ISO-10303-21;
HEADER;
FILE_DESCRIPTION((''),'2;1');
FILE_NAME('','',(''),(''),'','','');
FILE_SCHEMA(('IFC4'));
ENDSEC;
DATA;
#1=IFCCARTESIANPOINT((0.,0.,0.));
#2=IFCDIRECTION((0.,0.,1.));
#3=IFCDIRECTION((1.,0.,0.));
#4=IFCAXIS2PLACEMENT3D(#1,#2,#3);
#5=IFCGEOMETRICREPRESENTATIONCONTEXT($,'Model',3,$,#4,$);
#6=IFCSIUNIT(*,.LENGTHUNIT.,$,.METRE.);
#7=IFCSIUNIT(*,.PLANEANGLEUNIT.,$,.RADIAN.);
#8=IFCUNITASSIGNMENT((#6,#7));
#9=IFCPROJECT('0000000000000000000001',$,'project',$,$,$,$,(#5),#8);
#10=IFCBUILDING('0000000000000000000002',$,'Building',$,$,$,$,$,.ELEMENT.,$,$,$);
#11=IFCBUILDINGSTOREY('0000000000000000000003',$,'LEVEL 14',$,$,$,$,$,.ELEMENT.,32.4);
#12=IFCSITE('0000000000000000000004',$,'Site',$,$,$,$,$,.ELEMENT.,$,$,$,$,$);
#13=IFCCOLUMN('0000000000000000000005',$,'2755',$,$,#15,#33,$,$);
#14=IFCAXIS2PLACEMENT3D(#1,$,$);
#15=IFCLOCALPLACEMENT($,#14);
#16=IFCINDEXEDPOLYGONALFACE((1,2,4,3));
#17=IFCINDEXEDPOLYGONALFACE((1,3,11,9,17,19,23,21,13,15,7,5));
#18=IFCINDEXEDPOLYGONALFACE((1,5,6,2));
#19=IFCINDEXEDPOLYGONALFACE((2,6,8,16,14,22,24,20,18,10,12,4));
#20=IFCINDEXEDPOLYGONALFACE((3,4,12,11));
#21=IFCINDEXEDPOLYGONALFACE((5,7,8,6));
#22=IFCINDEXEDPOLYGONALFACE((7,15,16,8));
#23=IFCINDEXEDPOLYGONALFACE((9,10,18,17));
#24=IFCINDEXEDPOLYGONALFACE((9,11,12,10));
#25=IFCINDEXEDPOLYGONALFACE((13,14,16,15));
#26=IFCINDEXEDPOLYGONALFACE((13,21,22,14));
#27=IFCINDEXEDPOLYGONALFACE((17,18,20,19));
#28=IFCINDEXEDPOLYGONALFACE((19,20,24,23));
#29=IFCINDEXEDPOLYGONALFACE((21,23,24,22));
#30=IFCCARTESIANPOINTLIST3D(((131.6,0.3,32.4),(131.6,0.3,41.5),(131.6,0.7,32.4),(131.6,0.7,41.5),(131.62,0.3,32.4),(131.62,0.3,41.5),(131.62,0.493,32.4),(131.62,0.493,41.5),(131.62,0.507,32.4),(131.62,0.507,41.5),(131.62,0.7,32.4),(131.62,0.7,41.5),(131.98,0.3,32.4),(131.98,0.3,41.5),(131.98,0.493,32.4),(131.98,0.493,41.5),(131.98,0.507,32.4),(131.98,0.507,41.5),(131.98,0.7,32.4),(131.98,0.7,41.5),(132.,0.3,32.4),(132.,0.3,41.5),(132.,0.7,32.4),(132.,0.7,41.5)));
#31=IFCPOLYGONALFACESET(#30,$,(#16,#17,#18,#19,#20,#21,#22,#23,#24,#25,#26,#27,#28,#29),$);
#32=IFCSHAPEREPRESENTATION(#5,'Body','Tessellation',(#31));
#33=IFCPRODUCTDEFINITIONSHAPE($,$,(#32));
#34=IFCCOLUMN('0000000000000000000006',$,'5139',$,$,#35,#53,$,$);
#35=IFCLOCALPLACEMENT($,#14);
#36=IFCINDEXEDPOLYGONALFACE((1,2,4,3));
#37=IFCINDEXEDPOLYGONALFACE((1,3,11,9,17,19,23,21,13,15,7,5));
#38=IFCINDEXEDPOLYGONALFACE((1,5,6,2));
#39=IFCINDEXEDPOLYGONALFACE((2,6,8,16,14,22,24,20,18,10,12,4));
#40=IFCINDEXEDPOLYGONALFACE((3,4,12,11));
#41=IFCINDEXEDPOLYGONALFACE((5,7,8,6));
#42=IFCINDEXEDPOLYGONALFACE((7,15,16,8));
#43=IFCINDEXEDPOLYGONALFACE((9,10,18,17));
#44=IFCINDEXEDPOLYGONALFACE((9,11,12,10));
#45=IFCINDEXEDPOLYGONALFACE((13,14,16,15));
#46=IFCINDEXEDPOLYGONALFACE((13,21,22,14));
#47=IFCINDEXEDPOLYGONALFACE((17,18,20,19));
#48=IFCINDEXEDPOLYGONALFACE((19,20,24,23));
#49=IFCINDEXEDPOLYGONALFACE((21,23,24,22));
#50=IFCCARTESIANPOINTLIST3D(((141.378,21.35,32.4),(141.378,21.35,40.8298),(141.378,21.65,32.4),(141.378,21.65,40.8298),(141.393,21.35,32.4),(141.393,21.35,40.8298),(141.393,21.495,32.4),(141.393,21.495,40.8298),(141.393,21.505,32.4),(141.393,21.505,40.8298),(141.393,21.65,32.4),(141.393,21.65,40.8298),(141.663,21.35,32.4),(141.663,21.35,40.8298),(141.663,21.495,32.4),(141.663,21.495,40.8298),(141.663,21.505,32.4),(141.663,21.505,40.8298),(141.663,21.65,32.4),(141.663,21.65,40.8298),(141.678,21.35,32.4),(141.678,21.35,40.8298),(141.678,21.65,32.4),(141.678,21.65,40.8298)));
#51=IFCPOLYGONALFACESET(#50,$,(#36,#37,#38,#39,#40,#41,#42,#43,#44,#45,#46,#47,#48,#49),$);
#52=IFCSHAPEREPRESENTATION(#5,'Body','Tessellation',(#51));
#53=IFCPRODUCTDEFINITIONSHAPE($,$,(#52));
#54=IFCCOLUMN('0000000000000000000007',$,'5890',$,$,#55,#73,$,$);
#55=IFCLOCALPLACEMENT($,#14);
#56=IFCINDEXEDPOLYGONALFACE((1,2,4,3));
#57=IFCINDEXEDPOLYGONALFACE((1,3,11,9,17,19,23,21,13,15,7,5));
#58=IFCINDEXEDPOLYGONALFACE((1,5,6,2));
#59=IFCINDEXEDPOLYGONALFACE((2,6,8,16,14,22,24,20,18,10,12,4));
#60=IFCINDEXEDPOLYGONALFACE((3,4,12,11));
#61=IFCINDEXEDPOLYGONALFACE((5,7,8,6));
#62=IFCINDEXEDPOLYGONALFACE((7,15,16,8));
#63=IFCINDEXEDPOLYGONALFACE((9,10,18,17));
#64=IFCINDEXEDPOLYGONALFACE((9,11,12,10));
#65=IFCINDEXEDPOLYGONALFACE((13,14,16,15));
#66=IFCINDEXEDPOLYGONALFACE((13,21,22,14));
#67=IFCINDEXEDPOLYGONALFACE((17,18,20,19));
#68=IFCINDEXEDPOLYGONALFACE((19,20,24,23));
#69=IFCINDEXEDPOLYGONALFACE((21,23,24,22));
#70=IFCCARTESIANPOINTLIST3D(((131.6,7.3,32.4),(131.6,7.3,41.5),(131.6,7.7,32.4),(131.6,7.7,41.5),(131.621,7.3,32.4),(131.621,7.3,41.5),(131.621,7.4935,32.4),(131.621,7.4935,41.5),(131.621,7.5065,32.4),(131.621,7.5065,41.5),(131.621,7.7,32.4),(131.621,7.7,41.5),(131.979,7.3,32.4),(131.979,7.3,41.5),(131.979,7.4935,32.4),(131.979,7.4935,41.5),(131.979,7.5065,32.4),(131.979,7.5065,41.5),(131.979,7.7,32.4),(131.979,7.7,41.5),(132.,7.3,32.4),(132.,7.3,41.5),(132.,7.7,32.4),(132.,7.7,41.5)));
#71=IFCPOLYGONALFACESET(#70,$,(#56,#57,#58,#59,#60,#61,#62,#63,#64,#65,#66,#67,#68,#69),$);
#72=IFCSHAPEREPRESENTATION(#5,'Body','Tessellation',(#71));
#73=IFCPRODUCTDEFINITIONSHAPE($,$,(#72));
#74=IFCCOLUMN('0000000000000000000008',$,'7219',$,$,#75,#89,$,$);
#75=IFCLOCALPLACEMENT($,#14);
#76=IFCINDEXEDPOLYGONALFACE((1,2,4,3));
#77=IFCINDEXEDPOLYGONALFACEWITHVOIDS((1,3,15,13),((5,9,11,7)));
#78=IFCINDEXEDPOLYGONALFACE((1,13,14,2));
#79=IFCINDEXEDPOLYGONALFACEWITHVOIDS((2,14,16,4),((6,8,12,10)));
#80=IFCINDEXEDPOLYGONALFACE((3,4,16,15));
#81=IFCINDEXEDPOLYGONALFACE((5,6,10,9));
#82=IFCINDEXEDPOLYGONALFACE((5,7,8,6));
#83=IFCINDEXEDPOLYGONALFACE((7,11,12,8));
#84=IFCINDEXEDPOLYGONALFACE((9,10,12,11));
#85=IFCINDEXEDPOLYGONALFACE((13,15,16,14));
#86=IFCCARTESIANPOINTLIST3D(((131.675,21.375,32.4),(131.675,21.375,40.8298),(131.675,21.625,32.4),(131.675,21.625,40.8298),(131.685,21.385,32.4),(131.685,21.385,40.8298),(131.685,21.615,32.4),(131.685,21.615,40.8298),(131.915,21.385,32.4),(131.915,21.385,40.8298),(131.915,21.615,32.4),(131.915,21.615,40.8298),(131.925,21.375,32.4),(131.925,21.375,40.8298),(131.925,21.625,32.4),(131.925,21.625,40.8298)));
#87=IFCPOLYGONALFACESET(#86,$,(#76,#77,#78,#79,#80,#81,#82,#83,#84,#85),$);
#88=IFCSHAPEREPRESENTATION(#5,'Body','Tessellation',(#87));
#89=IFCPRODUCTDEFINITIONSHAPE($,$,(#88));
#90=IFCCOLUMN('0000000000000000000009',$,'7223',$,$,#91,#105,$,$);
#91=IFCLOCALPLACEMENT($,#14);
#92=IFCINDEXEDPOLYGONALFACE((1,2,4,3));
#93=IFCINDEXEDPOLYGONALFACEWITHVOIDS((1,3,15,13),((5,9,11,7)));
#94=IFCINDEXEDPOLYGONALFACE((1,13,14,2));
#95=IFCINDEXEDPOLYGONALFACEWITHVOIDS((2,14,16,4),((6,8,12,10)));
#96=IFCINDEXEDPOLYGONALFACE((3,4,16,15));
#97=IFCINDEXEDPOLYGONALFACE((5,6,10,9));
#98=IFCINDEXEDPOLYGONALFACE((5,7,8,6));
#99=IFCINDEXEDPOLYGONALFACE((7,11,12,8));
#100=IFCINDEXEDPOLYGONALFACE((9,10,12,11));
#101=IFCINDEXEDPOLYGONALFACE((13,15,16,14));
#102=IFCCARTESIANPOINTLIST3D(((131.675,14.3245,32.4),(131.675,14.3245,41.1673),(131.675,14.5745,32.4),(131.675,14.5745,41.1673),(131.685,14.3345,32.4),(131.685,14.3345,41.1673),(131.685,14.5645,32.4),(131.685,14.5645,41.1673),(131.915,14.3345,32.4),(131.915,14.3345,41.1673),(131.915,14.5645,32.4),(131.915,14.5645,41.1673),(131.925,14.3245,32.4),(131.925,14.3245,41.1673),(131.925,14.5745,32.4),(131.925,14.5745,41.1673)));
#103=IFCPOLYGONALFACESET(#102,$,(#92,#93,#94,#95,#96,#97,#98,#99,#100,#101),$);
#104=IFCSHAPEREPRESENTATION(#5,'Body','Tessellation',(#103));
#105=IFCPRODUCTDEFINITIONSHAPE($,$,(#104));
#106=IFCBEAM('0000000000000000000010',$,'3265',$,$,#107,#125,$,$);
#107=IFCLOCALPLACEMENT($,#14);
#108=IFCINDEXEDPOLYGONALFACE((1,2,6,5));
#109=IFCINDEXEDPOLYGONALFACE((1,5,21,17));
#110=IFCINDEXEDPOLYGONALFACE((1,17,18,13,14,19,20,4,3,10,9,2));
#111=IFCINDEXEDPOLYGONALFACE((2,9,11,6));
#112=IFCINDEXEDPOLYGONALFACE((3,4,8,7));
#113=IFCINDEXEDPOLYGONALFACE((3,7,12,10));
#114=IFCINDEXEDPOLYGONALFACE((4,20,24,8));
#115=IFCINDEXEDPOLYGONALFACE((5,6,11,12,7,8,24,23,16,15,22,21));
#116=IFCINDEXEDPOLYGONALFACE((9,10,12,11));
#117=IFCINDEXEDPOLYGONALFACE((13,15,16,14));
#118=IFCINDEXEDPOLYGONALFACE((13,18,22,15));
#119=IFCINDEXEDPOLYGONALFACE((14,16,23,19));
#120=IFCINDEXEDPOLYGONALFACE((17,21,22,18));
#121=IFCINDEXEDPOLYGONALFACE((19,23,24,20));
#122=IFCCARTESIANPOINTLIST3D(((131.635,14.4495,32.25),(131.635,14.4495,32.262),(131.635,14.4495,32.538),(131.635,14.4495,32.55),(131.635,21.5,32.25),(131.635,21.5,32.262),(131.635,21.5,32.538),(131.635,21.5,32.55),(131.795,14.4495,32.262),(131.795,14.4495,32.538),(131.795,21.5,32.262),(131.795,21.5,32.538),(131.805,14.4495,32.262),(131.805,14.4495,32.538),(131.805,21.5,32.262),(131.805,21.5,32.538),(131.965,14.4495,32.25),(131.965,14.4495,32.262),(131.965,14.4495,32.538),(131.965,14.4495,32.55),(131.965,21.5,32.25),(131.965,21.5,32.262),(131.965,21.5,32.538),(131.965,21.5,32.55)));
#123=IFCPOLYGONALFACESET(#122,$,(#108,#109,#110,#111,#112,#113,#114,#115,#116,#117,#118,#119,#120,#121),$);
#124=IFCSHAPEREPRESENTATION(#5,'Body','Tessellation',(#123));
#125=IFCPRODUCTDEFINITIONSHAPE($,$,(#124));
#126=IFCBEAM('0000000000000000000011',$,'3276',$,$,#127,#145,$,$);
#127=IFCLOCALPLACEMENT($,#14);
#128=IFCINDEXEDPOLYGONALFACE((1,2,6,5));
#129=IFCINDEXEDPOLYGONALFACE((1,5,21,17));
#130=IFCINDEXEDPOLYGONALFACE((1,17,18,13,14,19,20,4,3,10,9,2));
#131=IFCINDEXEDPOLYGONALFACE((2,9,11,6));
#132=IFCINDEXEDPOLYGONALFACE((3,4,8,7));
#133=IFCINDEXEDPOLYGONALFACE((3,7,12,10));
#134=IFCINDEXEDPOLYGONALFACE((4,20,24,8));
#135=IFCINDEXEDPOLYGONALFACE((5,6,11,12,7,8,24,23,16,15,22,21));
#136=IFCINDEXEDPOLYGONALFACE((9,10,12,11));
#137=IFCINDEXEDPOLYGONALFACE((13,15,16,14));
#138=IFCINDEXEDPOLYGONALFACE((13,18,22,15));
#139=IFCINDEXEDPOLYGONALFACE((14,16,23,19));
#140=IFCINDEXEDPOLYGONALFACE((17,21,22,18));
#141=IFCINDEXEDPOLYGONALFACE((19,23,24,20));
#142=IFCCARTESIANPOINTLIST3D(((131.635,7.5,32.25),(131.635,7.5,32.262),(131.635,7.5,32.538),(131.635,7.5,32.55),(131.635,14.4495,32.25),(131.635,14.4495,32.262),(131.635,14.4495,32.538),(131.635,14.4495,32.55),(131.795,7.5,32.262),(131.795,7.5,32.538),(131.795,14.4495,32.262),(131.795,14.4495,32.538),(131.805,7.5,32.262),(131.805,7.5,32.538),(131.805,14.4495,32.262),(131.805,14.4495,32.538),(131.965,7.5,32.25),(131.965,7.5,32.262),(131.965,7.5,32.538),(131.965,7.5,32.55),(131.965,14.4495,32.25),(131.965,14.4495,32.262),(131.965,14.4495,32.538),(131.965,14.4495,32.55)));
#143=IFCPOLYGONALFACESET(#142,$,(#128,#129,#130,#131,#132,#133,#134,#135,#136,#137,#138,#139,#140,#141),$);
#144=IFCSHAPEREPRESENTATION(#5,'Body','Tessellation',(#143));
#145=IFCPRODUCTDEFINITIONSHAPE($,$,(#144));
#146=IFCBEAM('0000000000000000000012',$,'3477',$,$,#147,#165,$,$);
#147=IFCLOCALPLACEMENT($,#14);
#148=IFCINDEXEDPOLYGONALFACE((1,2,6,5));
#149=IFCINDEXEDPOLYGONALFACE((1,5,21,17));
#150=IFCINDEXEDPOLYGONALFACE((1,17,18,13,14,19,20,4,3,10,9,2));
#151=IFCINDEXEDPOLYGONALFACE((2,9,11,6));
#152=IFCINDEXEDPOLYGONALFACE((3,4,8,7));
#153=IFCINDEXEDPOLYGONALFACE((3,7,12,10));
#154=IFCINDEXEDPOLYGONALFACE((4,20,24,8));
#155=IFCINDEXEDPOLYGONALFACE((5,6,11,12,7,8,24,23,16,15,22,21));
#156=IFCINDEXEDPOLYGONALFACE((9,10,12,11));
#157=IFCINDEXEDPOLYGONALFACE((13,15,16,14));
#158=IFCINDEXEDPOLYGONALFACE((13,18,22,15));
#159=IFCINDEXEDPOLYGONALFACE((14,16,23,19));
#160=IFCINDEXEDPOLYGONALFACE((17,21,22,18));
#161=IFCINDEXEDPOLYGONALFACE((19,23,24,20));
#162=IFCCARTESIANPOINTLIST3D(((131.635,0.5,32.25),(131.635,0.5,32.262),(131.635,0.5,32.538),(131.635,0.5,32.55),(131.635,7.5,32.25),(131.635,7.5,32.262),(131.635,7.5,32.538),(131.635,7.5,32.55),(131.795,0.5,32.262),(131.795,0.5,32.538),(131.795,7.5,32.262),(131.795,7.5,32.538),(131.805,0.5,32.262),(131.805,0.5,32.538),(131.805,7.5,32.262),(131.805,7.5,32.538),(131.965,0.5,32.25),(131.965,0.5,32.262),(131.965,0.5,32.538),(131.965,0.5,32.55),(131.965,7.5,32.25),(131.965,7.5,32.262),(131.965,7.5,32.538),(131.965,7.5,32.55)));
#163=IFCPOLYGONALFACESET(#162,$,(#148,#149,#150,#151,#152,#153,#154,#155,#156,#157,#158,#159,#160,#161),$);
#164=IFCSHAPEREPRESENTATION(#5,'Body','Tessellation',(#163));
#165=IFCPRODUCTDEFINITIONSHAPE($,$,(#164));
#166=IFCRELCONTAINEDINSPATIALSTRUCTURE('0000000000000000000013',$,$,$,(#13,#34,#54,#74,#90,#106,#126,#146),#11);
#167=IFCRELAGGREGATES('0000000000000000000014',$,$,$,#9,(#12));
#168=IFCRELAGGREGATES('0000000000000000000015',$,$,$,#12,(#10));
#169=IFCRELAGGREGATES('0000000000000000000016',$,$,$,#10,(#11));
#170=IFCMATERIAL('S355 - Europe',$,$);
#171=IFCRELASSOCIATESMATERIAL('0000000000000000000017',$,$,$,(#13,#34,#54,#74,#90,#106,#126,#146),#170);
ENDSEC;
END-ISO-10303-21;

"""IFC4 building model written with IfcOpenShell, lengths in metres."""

from ifc_helpers import new_model, si_unit, frame, origin_with_axes, origin_2d_with_axis, place, context, project, spatial, hollow_rectangle, i_section, extrude, material, material_profile, profile_set, profile_usage, element, save


model = new_model("IFC4")

# Units and contexts
model_context = context("Model", 3, world=origin_with_axes())
ifc_project = project(units=[si_unit("LENGTHUNIT", "METRE"), si_unit("PLANEANGLEUNIT", "RADIAN")], contexts=[model_context])

# Site, building, storey
site = spatial("IfcSite", under=ifc_project, Name="Site", CompositionType="ELEMENT")
building = spatial("IfcBuilding", under=site, Name="Building", CompositionType="ELEMENT")
storey = spatial("IfcBuildingStorey", under=building, Name="LEVEL 14", CompositionType="ELEMENT", Elevation=32.4)

# Columns
ifc_material = material(Name="S355 - Europe")
ifc_material_profile_1 = material_profile(ifc_material, i_section(OverallWidth=0.4, OverallDepth=0.4, WebThickness=0.014, FlangeThickness=0.02, at=origin_2d_with_axis()))
ifc_profile_set_1 = profile_set([ifc_material_profile_1])
ifc_profile_usage_1 = profile_usage(ifc_profile_set_1, cardinal=10)
column_1_placement = place(None, frame((131.8, 0.5, 32.4), z_axis=(0.0, 0.0, 1.0), x_axis=(0.0, -1.0, 0.0)))
element("IfcColumn", 1, at=column_1_placement, inside=storey, material=ifc_profile_usage_1, Name="2755", context=model_context, shape_type="SweptSolid", body=[
    extrude(i_section(OverallWidth=0.4, OverallDepth=0.4, WebThickness=0.014, FlangeThickness=0.02, at=origin_2d_with_axis()), origin_with_axes(), (0.0, 0.0, 1.0), 9.1),
])
ifc_material_profile_2 = material_profile(ifc_material, i_section(OverallWidth=0.3, OverallDepth=0.3, WebThickness=0.01, FlangeThickness=0.015, at=origin_2d_with_axis()))
ifc_profile_set_2 = profile_set([ifc_material_profile_2])
ifc_profile_usage_2 = profile_usage(ifc_profile_set_2, cardinal=10)
column_2_placement = place(None, frame((141.528, 21.5, 32.4), z_axis=(0.0, 0.0, 1.0), x_axis=(0.0, -1.0, 0.0)))
element("IfcColumn", 2, at=column_2_placement, inside=storey, material=ifc_profile_usage_2, Name="5139", context=model_context, shape_type="SweptSolid", body=[
    extrude(i_section(OverallWidth=0.3, OverallDepth=0.3, WebThickness=0.01, FlangeThickness=0.015, at=origin_2d_with_axis()), origin_with_axes(), (0.0, 0.0, 1.0), 8.4298),
])
ifc_material_profile_3 = material_profile(ifc_material, i_section(OverallWidth=0.4, OverallDepth=0.4, WebThickness=0.013, FlangeThickness=0.021, at=origin_2d_with_axis()))
ifc_profile_set_3 = profile_set([ifc_material_profile_3])
ifc_profile_usage_3 = profile_usage(ifc_profile_set_3, cardinal=10)
column_3_placement = place(None, frame((131.8, 7.5, 32.4), z_axis=(0.0, 0.0, 1.0), x_axis=(0.0, -1.0, 0.0)))
element("IfcColumn", 3, at=column_3_placement, inside=storey, material=ifc_profile_usage_3, Name="5890", context=model_context, shape_type="SweptSolid", body=[
    extrude(i_section(OverallWidth=0.4, OverallDepth=0.4, WebThickness=0.013, FlangeThickness=0.021, at=origin_2d_with_axis()), origin_with_axes(), (0.0, 0.0, 1.0), 9.1),
])
ifc_material_profile_4 = material_profile(ifc_material, hollow_rectangle(XDim=0.25, YDim=0.25, WallThickness=0.01, at=origin_2d_with_axis()))
ifc_profile_set_4 = profile_set([ifc_material_profile_4])
ifc_profile_usage_4 = profile_usage(ifc_profile_set_4, cardinal=10)
column_4_placement = place(None, frame((131.8, 21.5, 32.4), z_axis=(0.0, 0.0, 1.0), x_axis=(0.0, -1.0, 0.0)))
element("IfcColumn", 4, at=column_4_placement, inside=storey, material=ifc_profile_usage_4, Name="7219", context=model_context, shape_type="SweptSolid", body=[
    extrude(hollow_rectangle(XDim=0.25, YDim=0.25, WallThickness=0.01, at=origin_2d_with_axis()), origin_with_axes(), (0.0, 0.0, 1.0), 8.4298),
])
ifc_material_profile_5 = material_profile(ifc_material, hollow_rectangle(XDim=0.25, YDim=0.25, WallThickness=0.01, at=origin_2d_with_axis()))
ifc_profile_set_5 = profile_set([ifc_material_profile_5])
ifc_profile_usage_5 = profile_usage(ifc_profile_set_5, cardinal=10)
column_5_placement = place(None, frame((131.8, 14.4495, 32.4), z_axis=(0.0, 0.0, 1.0), x_axis=(0.0, -1.0, 0.0)))
element("IfcColumn", 5, at=column_5_placement, inside=storey, material=ifc_profile_usage_5, Name="7223", context=model_context, shape_type="SweptSolid", body=[
    extrude(hollow_rectangle(XDim=0.25, YDim=0.25, WallThickness=0.01, at=origin_2d_with_axis()), origin_with_axes(), (0.0, 0.0, 1.0), 8.7673),
])

# Beams
ifc_material_profile_6 = material_profile(ifc_material, i_section(OverallWidth=0.33, OverallDepth=0.3, WebThickness=0.01, FlangeThickness=0.012, at=origin_2d_with_axis()))
ifc_profile_set_6 = profile_set([ifc_material_profile_6])
ifc_profile_usage_6 = profile_usage(ifc_profile_set_6, cardinal=10)
beam_1_placement = place(None, frame((131.8, 21.5, 32.4), z_axis=(0.0, -1.0, 0.0), x_axis=(1.0, 0.0, 0.0)))
element("IfcBeam", 6, at=beam_1_placement, inside=storey, material=ifc_profile_usage_6, Name="3265", context=model_context, shape_type="SweptSolid", body=[
    extrude(i_section(OverallWidth=0.33, OverallDepth=0.3, WebThickness=0.01, FlangeThickness=0.012, at=origin_2d_with_axis()), origin_with_axes(), (0.0, 0.0, 1.0), 7.0505),
])
ifc_material_profile_7 = material_profile(ifc_material, i_section(OverallWidth=0.33, OverallDepth=0.3, WebThickness=0.01, FlangeThickness=0.012, at=origin_2d_with_axis()))
ifc_profile_set_7 = profile_set([ifc_material_profile_7])
ifc_profile_usage_7 = profile_usage(ifc_profile_set_7, cardinal=10)
beam_2_placement = place(None, frame((131.8, 14.4495, 32.4), z_axis=(0.0, -1.0, 0.0), x_axis=(1.0, 0.0, 0.0)))
element("IfcBeam", 7, at=beam_2_placement, inside=storey, material=ifc_profile_usage_7, Name="3276", context=model_context, shape_type="SweptSolid", body=[
    extrude(i_section(OverallWidth=0.33, OverallDepth=0.3, WebThickness=0.01, FlangeThickness=0.012, at=origin_2d_with_axis()), origin_with_axes(), (0.0, 0.0, 1.0), 6.9495),
])
ifc_material_profile_8 = material_profile(ifc_material, i_section(OverallWidth=0.33, OverallDepth=0.3, WebThickness=0.01, FlangeThickness=0.012, at=origin_2d_with_axis()))
ifc_profile_set_8 = profile_set([ifc_material_profile_8])
ifc_profile_usage_8 = profile_usage(ifc_profile_set_8, cardinal=10)
beam_3_placement = place(None, frame((131.8, 7.5, 32.4), z_axis=(0.0, -1.0, 0.0), x_axis=(1.0, 0.0, 0.0)))
element("IfcBeam", 8, at=beam_3_placement, inside=storey, material=ifc_profile_usage_8, Name="3477", context=model_context, shape_type="SweptSolid", body=[
    extrude(i_section(OverallWidth=0.33, OverallDepth=0.3, WebThickness=0.01, FlangeThickness=0.012, at=origin_2d_with_axis()), origin_with_axes(), (0.0, 0.0, 1.0), 7.0),
])

save(model, "model.ifc")
